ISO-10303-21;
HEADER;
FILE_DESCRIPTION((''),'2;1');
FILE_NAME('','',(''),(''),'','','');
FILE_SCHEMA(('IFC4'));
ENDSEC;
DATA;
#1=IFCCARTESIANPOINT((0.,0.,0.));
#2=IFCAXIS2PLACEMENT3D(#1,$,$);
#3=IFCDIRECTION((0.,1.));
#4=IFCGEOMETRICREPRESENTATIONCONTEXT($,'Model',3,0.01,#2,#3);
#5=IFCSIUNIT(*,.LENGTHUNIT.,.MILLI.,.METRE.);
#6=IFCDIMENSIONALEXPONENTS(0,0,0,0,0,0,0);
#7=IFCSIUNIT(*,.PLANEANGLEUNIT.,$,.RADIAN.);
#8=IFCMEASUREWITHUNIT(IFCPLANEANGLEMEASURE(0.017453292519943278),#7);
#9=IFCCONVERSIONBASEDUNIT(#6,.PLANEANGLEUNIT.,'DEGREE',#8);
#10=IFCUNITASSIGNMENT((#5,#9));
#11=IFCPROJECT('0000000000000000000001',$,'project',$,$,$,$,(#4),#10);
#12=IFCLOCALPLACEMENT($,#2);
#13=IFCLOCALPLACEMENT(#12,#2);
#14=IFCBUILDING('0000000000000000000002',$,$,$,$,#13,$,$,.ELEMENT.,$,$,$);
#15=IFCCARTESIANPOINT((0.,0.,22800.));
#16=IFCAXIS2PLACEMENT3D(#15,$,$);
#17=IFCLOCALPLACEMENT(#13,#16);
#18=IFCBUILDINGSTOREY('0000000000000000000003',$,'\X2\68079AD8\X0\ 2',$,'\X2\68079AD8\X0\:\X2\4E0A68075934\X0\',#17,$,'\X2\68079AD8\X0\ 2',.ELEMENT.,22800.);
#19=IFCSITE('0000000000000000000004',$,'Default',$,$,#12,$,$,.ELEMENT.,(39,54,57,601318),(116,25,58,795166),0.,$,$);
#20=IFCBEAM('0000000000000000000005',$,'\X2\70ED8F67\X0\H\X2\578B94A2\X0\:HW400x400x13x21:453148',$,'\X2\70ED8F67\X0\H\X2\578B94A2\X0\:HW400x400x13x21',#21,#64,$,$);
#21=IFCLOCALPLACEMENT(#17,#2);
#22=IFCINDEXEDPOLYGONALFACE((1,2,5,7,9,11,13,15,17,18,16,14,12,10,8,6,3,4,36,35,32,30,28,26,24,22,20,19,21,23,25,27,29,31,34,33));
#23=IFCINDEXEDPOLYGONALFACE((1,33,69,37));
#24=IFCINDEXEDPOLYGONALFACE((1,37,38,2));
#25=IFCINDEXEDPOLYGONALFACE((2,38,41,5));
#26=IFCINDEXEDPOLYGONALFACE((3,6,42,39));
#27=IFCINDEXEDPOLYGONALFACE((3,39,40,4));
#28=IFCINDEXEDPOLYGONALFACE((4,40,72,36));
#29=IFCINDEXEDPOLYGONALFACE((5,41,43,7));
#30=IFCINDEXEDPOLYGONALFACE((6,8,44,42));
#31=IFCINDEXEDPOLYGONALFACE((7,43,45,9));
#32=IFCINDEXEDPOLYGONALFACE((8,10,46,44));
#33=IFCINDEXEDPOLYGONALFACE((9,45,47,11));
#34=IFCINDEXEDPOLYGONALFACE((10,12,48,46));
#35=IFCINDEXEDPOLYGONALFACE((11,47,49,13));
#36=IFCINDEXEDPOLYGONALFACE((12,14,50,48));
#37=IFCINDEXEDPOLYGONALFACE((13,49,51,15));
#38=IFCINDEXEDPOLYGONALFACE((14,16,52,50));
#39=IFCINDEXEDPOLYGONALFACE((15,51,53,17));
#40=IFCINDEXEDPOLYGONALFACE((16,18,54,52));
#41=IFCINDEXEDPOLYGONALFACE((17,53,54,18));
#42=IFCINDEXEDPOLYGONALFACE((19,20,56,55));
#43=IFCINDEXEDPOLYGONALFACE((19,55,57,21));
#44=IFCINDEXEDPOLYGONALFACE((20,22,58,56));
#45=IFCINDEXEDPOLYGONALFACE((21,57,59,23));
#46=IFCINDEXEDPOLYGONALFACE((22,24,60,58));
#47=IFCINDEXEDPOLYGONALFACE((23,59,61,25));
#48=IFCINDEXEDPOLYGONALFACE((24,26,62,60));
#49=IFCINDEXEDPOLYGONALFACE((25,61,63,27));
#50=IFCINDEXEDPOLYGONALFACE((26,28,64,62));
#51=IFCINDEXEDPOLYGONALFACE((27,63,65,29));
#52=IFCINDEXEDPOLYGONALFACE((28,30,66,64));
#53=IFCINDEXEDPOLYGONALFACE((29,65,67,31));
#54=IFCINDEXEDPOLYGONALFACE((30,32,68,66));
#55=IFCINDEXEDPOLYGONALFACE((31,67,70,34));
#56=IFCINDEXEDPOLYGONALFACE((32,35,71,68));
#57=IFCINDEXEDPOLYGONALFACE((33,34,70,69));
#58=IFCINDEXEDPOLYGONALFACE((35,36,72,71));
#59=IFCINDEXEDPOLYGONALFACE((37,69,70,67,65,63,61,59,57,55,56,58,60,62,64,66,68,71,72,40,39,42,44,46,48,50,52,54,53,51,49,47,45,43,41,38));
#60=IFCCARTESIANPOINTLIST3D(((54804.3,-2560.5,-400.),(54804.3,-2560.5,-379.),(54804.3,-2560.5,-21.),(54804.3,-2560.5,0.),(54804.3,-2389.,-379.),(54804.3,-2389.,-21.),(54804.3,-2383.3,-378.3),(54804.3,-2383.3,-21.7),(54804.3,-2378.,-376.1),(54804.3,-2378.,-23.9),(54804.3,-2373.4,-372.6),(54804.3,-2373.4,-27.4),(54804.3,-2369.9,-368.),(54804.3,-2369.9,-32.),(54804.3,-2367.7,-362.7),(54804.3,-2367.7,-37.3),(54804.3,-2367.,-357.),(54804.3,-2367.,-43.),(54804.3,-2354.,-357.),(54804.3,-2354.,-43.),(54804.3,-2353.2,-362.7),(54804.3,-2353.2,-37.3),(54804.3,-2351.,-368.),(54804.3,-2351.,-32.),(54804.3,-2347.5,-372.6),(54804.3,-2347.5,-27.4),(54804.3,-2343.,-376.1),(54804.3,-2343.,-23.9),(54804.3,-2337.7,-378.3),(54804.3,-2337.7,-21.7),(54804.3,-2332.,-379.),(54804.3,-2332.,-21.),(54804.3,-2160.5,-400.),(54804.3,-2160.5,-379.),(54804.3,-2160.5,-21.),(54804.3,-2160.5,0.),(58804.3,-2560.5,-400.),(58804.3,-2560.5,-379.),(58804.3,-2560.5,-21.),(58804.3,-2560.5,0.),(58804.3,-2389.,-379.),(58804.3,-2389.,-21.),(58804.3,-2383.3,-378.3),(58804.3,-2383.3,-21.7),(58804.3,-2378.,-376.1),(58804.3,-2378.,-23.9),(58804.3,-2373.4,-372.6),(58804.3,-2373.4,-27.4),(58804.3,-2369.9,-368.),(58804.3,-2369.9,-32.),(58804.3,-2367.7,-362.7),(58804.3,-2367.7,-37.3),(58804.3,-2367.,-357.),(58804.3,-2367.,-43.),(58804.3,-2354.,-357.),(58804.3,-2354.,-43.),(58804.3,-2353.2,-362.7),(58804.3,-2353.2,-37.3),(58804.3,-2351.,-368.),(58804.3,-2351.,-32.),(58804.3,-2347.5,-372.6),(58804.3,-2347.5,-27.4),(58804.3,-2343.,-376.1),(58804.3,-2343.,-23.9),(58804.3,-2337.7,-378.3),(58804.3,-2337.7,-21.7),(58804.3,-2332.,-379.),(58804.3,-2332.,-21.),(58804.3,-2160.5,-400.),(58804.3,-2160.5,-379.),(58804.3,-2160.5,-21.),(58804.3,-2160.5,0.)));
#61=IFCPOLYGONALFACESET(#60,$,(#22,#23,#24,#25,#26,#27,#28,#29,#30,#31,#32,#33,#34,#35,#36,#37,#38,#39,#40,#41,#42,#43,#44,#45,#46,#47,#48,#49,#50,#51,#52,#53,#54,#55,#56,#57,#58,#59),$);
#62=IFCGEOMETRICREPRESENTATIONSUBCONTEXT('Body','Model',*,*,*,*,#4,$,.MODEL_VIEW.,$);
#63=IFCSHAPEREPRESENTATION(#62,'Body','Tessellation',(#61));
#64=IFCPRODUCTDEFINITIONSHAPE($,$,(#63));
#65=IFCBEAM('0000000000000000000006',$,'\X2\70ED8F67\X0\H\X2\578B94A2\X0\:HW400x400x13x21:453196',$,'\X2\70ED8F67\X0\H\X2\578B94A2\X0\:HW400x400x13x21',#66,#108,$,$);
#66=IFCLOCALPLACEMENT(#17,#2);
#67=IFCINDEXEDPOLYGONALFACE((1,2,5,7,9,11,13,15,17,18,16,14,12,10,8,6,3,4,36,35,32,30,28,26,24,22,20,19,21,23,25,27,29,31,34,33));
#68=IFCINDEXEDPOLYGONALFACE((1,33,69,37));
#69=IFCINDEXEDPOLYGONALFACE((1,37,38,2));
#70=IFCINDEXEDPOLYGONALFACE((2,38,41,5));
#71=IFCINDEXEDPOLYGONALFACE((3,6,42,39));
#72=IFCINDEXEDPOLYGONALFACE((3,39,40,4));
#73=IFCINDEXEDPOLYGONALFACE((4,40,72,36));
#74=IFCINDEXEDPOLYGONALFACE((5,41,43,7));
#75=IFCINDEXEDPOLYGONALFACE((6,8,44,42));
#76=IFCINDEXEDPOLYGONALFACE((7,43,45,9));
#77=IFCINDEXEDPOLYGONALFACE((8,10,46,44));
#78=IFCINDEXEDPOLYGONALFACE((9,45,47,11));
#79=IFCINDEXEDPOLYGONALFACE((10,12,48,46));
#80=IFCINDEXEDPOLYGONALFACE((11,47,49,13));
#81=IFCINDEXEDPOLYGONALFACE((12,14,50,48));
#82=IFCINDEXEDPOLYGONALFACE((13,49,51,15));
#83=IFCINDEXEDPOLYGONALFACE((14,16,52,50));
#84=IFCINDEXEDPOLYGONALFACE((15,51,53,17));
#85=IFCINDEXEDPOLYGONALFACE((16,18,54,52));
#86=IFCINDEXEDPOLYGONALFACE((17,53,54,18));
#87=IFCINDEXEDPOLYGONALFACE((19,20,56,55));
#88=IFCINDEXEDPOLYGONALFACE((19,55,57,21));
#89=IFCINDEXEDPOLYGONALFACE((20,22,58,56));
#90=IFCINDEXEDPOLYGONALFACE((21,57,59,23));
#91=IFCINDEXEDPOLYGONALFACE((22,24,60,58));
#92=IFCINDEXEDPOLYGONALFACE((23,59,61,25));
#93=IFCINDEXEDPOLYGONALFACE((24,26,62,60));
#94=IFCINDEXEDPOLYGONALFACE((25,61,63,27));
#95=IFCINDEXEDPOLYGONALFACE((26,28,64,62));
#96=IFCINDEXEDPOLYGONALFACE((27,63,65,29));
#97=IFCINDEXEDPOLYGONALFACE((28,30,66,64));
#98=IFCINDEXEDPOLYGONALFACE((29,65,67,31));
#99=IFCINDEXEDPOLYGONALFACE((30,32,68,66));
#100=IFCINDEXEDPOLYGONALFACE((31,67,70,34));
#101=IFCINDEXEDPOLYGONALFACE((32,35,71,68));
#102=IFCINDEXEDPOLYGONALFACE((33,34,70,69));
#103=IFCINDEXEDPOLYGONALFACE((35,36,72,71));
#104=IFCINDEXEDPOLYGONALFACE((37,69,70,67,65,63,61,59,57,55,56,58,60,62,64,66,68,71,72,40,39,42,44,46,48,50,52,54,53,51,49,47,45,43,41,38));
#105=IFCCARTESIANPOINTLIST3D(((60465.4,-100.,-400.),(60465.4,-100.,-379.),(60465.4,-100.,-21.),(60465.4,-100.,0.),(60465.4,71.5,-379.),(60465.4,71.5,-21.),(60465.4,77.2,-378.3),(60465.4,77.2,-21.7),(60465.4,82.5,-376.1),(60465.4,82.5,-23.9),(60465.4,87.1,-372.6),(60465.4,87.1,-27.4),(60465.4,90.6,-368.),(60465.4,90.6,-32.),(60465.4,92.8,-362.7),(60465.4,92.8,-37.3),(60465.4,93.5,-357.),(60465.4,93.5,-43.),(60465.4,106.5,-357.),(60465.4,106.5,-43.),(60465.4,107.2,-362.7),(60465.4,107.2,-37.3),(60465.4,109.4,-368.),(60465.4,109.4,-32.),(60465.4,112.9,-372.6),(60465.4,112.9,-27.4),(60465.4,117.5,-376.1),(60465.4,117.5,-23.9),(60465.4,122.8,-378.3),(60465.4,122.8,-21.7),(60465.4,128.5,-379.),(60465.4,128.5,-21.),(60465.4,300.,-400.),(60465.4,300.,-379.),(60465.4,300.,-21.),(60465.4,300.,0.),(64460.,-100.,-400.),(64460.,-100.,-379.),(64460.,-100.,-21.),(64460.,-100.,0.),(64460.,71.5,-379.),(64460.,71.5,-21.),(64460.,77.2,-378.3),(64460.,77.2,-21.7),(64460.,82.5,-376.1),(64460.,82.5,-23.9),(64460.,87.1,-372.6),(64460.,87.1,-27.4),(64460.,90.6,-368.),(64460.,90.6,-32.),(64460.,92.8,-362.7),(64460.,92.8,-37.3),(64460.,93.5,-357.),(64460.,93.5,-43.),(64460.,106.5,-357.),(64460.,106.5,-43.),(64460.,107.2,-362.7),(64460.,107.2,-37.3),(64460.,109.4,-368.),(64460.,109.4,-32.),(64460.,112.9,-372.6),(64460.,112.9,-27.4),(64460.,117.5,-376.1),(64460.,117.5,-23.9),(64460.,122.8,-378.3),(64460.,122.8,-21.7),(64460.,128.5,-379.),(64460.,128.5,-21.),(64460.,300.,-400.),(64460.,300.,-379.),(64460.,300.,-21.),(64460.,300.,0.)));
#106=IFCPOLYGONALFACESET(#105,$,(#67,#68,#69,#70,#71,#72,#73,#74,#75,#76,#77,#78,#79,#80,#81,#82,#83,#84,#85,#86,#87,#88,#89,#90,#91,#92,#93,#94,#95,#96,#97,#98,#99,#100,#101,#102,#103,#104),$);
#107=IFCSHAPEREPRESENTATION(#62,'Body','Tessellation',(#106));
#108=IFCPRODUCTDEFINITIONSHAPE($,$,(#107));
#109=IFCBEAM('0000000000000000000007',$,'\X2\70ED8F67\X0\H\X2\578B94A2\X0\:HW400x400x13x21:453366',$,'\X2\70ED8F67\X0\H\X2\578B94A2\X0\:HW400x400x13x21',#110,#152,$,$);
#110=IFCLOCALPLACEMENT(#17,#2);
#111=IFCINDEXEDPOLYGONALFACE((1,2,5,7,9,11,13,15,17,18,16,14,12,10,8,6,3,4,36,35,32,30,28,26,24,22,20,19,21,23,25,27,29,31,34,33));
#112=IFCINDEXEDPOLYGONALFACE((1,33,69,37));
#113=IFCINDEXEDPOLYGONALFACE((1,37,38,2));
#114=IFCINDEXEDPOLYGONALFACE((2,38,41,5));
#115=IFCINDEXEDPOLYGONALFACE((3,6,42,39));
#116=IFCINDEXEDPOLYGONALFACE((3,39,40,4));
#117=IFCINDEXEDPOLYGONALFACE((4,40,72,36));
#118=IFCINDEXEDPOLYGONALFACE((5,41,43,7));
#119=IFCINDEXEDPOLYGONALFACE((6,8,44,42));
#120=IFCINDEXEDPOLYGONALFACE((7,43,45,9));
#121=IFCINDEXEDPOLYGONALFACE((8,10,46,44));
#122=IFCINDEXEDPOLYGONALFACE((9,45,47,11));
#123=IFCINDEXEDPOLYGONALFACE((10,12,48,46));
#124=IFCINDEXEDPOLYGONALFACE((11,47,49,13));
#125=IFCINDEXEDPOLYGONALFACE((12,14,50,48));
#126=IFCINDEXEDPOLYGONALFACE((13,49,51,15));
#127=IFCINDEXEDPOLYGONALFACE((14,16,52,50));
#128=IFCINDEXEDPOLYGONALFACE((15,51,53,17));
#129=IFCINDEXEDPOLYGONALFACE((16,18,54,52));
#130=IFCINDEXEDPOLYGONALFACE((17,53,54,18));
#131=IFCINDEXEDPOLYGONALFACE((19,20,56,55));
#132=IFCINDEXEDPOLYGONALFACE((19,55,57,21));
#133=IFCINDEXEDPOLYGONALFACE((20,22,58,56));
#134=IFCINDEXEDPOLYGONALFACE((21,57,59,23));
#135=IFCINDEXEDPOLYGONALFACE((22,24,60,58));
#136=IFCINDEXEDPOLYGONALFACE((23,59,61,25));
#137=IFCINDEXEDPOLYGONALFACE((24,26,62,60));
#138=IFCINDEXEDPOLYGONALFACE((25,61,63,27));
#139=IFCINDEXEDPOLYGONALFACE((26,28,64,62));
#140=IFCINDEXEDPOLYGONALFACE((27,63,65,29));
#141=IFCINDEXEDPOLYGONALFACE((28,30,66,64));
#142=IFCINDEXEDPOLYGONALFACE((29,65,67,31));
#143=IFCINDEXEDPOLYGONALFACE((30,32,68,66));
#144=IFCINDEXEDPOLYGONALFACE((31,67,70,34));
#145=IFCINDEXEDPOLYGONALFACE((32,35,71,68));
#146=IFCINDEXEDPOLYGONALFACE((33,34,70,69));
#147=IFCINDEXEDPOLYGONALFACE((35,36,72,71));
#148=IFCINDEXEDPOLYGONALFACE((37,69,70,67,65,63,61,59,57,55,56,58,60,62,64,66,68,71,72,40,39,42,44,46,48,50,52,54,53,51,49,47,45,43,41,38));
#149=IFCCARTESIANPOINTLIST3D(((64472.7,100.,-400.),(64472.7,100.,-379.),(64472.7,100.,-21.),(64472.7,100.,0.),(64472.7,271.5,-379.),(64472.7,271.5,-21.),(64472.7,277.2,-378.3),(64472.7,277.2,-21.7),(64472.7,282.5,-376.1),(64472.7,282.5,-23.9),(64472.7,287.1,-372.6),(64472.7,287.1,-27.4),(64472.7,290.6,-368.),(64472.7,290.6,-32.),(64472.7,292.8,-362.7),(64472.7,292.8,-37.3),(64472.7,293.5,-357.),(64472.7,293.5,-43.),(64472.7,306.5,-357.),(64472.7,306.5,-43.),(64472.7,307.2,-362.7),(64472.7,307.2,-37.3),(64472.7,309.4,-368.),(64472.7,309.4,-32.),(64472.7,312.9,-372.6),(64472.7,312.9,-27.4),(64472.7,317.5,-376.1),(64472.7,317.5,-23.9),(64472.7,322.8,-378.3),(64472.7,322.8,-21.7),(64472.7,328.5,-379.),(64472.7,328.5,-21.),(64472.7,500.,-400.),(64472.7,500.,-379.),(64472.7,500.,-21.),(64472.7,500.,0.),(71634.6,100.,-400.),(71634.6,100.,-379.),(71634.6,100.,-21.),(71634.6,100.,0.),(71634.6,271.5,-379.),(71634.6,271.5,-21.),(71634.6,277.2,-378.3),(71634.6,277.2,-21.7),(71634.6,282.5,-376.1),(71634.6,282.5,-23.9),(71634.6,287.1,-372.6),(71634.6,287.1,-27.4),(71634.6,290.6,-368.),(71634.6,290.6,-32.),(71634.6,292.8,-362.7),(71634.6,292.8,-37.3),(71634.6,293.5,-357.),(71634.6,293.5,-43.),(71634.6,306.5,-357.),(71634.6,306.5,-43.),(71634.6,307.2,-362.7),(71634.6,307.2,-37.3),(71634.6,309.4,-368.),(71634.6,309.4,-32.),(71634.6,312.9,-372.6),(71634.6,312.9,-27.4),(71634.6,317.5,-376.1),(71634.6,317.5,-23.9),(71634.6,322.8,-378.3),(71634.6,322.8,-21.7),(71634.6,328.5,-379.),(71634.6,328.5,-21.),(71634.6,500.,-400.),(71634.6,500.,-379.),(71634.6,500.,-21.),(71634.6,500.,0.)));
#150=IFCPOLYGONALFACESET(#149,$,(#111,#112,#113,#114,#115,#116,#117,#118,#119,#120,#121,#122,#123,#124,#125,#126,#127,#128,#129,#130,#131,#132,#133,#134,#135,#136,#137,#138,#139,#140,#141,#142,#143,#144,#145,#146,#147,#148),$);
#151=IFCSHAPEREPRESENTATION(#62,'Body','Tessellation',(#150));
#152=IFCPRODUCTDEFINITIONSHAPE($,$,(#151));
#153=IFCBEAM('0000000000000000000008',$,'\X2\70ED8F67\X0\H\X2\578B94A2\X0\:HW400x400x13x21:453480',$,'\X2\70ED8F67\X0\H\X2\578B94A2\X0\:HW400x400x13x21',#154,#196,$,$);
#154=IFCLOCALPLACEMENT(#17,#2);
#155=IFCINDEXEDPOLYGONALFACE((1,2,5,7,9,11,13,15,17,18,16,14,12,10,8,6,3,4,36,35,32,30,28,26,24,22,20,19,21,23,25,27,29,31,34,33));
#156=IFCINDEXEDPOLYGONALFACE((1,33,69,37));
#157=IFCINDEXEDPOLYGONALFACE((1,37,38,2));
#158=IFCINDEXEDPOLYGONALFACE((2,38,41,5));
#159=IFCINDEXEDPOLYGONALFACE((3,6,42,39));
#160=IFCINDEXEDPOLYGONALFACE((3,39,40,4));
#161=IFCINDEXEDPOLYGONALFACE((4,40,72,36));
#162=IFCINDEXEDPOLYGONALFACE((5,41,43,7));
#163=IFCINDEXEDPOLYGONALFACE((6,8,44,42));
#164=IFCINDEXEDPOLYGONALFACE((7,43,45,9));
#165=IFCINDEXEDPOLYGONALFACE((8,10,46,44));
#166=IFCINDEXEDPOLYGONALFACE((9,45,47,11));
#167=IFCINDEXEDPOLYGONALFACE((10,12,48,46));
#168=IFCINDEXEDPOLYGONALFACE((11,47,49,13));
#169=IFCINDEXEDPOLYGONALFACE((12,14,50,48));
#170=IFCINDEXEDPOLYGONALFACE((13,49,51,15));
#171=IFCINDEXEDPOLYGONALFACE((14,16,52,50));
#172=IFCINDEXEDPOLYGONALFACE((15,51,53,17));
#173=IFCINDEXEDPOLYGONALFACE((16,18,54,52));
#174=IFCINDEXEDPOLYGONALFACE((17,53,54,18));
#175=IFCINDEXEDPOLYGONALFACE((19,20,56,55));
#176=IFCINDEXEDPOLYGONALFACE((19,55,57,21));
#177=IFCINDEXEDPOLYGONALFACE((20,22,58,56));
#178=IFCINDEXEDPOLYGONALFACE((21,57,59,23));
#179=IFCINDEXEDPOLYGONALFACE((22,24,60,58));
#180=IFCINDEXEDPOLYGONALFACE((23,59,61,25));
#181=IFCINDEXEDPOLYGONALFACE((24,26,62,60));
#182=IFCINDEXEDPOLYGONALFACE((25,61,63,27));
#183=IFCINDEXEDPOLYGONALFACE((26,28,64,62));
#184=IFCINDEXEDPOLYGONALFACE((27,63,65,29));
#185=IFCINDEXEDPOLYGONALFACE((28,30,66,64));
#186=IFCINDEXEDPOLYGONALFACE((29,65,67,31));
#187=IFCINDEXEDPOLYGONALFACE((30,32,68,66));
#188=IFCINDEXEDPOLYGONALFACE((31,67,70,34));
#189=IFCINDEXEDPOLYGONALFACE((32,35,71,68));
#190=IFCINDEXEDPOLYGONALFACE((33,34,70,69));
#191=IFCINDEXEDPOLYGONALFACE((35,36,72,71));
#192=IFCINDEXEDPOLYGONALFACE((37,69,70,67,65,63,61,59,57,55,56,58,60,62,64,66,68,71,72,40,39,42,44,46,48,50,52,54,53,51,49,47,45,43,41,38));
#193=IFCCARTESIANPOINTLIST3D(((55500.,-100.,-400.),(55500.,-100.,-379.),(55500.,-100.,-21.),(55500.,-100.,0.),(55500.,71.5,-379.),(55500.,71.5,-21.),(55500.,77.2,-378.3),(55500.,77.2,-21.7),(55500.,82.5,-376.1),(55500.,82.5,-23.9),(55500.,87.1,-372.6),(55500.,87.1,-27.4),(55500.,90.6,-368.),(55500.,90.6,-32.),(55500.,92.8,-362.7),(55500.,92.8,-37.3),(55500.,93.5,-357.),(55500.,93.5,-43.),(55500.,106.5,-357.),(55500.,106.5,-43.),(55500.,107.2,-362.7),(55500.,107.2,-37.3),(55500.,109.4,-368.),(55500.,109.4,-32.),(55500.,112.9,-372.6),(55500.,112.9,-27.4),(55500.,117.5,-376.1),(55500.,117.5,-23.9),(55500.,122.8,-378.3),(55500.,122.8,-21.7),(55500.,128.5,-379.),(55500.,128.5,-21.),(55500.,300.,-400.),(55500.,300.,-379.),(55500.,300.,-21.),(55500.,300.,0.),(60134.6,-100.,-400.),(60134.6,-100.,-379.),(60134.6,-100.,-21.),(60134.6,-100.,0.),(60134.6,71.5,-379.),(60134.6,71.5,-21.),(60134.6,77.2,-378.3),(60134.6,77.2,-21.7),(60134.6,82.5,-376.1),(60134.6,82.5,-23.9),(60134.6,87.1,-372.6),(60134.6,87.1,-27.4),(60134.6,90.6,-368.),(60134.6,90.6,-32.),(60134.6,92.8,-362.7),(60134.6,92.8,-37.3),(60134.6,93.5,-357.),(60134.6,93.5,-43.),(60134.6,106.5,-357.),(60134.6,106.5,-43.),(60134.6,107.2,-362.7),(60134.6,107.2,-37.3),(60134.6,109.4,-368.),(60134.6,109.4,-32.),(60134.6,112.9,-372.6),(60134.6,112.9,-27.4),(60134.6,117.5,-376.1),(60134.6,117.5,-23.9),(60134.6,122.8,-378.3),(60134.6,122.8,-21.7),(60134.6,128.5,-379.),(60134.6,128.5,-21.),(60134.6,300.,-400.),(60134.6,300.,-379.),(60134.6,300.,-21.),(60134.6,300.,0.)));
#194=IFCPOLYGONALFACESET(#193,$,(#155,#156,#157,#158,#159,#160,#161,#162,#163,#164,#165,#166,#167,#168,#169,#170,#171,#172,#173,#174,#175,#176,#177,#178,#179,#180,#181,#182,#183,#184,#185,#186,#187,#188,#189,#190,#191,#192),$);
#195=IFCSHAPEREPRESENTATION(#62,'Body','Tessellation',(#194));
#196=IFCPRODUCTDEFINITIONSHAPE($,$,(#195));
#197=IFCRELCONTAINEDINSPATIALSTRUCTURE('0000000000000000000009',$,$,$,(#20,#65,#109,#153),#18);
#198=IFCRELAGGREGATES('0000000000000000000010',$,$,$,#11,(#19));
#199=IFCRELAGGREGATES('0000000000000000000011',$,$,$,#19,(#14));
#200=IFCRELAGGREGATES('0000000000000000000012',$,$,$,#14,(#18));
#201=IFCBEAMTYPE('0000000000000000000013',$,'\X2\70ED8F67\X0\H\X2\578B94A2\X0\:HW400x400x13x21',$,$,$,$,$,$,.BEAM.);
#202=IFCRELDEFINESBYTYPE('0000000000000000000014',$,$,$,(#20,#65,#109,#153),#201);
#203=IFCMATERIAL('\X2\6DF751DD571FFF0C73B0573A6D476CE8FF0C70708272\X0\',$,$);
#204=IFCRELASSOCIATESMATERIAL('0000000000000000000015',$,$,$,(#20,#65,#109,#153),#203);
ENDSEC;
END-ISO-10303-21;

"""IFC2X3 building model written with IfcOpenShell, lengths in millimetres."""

from ifc_helpers import new_model, entity, si_unit, converted_unit, direction, frame, frame_2d, origin, place, context, subcontext, project, spatial, i_section, extrude, material, type_object, element, save


model = new_model("IFC2X3")

# Units and contexts
model_context = context("Model", 3, precision=0.01, world=origin(), true_north=direction((0.0, 1.0)))
body_context = subcontext(model_context, "Body", "Model", "MODEL_VIEW")
ifc_project = project(units=[si_unit("LENGTHUNIT", "METRE", prefix="MILLI"), converted_unit("PLANEANGLEUNIT", "DEGREE", entity("IfcPlaneAngleMeasure", 0.017453292519943278), si_unit("PLANEANGLEUNIT", "RADIAN"), dimensions=[0, 0, 0, 0, 0, 0, 0])], contexts=[model_context])

# Site, building, storey
site_placement = place(None, origin())
site = spatial("IfcSite", under=ifc_project, at=site_placement, Name="Default", CompositionType="ELEMENT", RefLatitude=(39, 54, 57, 601318), RefLongitude=(116, 25, 58, 795166), RefElevation=0.0)
building_placement = place(site_placement, origin())
building = spatial("IfcBuilding", under=site, at=building_placement, CompositionType="ELEMENT")
storey_placement = place(building_placement, frame((0.0, 0.0, 22800.0)))
storey = spatial("IfcBuildingStorey", under=building, at=storey_placement, Name="标高 2", ObjectType="标高:上标头", LongName="标高 2", CompositionType="ELEMENT", Elevation=22800.0)

# Beams
ifc_material = material(Name="混凝土，现场浇注，灰色")
beam_type = type_object("IfcBeamType", Name="热轧H型钢:HW400x400x13x21", PredefinedType="BEAM")
beam_1_placement = place(storey_placement, frame((54804.3, -2360.5, 0.0)))
element("IfcBeam", 1, at=beam_1_placement, inside=storey, type_object=beam_type, material=ifc_material, Name="热轧H型钢:HW400x400x13x21:453148", ObjectType="热轧H型钢:HW400x400x13x21", context=body_context, shape_type="SweptSolid", body=[
    extrude(i_section(OverallWidth=400.0, OverallDepth=400.0, WebThickness=13.0, FlangeThickness=21.0, FilletRadius=22.0, at=frame_2d((0.0, 0.0), x_axis=(0.0, 1.0))), frame((0.0, 0.0, -200.0), z_axis=(1.0, 0.0, 0.0), x_axis=(0.0, 0.0, -1.0)), (0.0, 0.0, 1.0), 4000.0),
])
beam_2_placement = place(storey_placement, frame((60300.0, 100.0, 0.0)))
element("IfcBeam", 2, at=beam_2_placement, inside=storey, type_object=beam_type, material=ifc_material, Name="热轧H型钢:HW400x400x13x21:453196", ObjectType="热轧H型钢:HW400x400x13x21", context=body_context, shape_type="SweptSolid", body=[
    extrude(i_section(OverallWidth=400.0, OverallDepth=400.0, WebThickness=13.0, FlangeThickness=21.0, FilletRadius=22.0, at=frame_2d((0.0, 0.0), x_axis=(0.0, 1.0))), frame((165.4, 0.0, -200.0), z_axis=(1.0, 0.0, 0.0), x_axis=(0.0, 0.0, -1.0)), (0.0, 0.0, 1.0), 3994.6),
])
beam_3_placement = place(storey_placement, frame((71900.0, 300.0, 0.0), z_axis=(0.0, 0.0, 1.0), x_axis=(-1.0, 0.0, 0.0)))
element("IfcBeam", 3, at=beam_3_placement, inside=storey, type_object=beam_type, material=ifc_material, Name="热轧H型钢:HW400x400x13x21:453366", ObjectType="热轧H型钢:HW400x400x13x21", context=body_context, shape_type="SweptSolid", body=[
    extrude(i_section(OverallWidth=400.0, OverallDepth=400.0, WebThickness=13.0, FlangeThickness=21.0, FilletRadius=22.0, at=frame_2d((0.0, 0.0), x_axis=(0.0, 1.0))), frame((265.4, 0.0, -200.0), z_axis=(1.0, 0.0, 0.0), x_axis=(0.0, 0.0, -1.0)), (0.0, 0.0, 1.0), 7161.9),
])
beam_4_placement = place(storey_placement, frame((60300.0, 100.0, 0.0), z_axis=(0.0, 0.0, 1.0), x_axis=(-1.0, 0.0, 0.0)))
element("IfcBeam", 4, at=beam_4_placement, inside=storey, type_object=beam_type, material=ifc_material, Name="热轧H型钢:HW400x400x13x21:453480", ObjectType="热轧H型钢:HW400x400x13x21", context=body_context, shape_type="SweptSolid", body=[
    extrude(i_section(OverallWidth=400.0, OverallDepth=400.0, WebThickness=13.0, FlangeThickness=21.0, FilletRadius=22.0, at=frame_2d((0.0, 0.0), x_axis=(0.0, 1.0))), frame((165.4, 0.0, -200.0), z_axis=(1.0, 0.0, 0.0), x_axis=(0.0, 0.0, -1.0)), (0.0, 0.0, 1.0), 4634.6),
])

save(model, "model.ifc")
